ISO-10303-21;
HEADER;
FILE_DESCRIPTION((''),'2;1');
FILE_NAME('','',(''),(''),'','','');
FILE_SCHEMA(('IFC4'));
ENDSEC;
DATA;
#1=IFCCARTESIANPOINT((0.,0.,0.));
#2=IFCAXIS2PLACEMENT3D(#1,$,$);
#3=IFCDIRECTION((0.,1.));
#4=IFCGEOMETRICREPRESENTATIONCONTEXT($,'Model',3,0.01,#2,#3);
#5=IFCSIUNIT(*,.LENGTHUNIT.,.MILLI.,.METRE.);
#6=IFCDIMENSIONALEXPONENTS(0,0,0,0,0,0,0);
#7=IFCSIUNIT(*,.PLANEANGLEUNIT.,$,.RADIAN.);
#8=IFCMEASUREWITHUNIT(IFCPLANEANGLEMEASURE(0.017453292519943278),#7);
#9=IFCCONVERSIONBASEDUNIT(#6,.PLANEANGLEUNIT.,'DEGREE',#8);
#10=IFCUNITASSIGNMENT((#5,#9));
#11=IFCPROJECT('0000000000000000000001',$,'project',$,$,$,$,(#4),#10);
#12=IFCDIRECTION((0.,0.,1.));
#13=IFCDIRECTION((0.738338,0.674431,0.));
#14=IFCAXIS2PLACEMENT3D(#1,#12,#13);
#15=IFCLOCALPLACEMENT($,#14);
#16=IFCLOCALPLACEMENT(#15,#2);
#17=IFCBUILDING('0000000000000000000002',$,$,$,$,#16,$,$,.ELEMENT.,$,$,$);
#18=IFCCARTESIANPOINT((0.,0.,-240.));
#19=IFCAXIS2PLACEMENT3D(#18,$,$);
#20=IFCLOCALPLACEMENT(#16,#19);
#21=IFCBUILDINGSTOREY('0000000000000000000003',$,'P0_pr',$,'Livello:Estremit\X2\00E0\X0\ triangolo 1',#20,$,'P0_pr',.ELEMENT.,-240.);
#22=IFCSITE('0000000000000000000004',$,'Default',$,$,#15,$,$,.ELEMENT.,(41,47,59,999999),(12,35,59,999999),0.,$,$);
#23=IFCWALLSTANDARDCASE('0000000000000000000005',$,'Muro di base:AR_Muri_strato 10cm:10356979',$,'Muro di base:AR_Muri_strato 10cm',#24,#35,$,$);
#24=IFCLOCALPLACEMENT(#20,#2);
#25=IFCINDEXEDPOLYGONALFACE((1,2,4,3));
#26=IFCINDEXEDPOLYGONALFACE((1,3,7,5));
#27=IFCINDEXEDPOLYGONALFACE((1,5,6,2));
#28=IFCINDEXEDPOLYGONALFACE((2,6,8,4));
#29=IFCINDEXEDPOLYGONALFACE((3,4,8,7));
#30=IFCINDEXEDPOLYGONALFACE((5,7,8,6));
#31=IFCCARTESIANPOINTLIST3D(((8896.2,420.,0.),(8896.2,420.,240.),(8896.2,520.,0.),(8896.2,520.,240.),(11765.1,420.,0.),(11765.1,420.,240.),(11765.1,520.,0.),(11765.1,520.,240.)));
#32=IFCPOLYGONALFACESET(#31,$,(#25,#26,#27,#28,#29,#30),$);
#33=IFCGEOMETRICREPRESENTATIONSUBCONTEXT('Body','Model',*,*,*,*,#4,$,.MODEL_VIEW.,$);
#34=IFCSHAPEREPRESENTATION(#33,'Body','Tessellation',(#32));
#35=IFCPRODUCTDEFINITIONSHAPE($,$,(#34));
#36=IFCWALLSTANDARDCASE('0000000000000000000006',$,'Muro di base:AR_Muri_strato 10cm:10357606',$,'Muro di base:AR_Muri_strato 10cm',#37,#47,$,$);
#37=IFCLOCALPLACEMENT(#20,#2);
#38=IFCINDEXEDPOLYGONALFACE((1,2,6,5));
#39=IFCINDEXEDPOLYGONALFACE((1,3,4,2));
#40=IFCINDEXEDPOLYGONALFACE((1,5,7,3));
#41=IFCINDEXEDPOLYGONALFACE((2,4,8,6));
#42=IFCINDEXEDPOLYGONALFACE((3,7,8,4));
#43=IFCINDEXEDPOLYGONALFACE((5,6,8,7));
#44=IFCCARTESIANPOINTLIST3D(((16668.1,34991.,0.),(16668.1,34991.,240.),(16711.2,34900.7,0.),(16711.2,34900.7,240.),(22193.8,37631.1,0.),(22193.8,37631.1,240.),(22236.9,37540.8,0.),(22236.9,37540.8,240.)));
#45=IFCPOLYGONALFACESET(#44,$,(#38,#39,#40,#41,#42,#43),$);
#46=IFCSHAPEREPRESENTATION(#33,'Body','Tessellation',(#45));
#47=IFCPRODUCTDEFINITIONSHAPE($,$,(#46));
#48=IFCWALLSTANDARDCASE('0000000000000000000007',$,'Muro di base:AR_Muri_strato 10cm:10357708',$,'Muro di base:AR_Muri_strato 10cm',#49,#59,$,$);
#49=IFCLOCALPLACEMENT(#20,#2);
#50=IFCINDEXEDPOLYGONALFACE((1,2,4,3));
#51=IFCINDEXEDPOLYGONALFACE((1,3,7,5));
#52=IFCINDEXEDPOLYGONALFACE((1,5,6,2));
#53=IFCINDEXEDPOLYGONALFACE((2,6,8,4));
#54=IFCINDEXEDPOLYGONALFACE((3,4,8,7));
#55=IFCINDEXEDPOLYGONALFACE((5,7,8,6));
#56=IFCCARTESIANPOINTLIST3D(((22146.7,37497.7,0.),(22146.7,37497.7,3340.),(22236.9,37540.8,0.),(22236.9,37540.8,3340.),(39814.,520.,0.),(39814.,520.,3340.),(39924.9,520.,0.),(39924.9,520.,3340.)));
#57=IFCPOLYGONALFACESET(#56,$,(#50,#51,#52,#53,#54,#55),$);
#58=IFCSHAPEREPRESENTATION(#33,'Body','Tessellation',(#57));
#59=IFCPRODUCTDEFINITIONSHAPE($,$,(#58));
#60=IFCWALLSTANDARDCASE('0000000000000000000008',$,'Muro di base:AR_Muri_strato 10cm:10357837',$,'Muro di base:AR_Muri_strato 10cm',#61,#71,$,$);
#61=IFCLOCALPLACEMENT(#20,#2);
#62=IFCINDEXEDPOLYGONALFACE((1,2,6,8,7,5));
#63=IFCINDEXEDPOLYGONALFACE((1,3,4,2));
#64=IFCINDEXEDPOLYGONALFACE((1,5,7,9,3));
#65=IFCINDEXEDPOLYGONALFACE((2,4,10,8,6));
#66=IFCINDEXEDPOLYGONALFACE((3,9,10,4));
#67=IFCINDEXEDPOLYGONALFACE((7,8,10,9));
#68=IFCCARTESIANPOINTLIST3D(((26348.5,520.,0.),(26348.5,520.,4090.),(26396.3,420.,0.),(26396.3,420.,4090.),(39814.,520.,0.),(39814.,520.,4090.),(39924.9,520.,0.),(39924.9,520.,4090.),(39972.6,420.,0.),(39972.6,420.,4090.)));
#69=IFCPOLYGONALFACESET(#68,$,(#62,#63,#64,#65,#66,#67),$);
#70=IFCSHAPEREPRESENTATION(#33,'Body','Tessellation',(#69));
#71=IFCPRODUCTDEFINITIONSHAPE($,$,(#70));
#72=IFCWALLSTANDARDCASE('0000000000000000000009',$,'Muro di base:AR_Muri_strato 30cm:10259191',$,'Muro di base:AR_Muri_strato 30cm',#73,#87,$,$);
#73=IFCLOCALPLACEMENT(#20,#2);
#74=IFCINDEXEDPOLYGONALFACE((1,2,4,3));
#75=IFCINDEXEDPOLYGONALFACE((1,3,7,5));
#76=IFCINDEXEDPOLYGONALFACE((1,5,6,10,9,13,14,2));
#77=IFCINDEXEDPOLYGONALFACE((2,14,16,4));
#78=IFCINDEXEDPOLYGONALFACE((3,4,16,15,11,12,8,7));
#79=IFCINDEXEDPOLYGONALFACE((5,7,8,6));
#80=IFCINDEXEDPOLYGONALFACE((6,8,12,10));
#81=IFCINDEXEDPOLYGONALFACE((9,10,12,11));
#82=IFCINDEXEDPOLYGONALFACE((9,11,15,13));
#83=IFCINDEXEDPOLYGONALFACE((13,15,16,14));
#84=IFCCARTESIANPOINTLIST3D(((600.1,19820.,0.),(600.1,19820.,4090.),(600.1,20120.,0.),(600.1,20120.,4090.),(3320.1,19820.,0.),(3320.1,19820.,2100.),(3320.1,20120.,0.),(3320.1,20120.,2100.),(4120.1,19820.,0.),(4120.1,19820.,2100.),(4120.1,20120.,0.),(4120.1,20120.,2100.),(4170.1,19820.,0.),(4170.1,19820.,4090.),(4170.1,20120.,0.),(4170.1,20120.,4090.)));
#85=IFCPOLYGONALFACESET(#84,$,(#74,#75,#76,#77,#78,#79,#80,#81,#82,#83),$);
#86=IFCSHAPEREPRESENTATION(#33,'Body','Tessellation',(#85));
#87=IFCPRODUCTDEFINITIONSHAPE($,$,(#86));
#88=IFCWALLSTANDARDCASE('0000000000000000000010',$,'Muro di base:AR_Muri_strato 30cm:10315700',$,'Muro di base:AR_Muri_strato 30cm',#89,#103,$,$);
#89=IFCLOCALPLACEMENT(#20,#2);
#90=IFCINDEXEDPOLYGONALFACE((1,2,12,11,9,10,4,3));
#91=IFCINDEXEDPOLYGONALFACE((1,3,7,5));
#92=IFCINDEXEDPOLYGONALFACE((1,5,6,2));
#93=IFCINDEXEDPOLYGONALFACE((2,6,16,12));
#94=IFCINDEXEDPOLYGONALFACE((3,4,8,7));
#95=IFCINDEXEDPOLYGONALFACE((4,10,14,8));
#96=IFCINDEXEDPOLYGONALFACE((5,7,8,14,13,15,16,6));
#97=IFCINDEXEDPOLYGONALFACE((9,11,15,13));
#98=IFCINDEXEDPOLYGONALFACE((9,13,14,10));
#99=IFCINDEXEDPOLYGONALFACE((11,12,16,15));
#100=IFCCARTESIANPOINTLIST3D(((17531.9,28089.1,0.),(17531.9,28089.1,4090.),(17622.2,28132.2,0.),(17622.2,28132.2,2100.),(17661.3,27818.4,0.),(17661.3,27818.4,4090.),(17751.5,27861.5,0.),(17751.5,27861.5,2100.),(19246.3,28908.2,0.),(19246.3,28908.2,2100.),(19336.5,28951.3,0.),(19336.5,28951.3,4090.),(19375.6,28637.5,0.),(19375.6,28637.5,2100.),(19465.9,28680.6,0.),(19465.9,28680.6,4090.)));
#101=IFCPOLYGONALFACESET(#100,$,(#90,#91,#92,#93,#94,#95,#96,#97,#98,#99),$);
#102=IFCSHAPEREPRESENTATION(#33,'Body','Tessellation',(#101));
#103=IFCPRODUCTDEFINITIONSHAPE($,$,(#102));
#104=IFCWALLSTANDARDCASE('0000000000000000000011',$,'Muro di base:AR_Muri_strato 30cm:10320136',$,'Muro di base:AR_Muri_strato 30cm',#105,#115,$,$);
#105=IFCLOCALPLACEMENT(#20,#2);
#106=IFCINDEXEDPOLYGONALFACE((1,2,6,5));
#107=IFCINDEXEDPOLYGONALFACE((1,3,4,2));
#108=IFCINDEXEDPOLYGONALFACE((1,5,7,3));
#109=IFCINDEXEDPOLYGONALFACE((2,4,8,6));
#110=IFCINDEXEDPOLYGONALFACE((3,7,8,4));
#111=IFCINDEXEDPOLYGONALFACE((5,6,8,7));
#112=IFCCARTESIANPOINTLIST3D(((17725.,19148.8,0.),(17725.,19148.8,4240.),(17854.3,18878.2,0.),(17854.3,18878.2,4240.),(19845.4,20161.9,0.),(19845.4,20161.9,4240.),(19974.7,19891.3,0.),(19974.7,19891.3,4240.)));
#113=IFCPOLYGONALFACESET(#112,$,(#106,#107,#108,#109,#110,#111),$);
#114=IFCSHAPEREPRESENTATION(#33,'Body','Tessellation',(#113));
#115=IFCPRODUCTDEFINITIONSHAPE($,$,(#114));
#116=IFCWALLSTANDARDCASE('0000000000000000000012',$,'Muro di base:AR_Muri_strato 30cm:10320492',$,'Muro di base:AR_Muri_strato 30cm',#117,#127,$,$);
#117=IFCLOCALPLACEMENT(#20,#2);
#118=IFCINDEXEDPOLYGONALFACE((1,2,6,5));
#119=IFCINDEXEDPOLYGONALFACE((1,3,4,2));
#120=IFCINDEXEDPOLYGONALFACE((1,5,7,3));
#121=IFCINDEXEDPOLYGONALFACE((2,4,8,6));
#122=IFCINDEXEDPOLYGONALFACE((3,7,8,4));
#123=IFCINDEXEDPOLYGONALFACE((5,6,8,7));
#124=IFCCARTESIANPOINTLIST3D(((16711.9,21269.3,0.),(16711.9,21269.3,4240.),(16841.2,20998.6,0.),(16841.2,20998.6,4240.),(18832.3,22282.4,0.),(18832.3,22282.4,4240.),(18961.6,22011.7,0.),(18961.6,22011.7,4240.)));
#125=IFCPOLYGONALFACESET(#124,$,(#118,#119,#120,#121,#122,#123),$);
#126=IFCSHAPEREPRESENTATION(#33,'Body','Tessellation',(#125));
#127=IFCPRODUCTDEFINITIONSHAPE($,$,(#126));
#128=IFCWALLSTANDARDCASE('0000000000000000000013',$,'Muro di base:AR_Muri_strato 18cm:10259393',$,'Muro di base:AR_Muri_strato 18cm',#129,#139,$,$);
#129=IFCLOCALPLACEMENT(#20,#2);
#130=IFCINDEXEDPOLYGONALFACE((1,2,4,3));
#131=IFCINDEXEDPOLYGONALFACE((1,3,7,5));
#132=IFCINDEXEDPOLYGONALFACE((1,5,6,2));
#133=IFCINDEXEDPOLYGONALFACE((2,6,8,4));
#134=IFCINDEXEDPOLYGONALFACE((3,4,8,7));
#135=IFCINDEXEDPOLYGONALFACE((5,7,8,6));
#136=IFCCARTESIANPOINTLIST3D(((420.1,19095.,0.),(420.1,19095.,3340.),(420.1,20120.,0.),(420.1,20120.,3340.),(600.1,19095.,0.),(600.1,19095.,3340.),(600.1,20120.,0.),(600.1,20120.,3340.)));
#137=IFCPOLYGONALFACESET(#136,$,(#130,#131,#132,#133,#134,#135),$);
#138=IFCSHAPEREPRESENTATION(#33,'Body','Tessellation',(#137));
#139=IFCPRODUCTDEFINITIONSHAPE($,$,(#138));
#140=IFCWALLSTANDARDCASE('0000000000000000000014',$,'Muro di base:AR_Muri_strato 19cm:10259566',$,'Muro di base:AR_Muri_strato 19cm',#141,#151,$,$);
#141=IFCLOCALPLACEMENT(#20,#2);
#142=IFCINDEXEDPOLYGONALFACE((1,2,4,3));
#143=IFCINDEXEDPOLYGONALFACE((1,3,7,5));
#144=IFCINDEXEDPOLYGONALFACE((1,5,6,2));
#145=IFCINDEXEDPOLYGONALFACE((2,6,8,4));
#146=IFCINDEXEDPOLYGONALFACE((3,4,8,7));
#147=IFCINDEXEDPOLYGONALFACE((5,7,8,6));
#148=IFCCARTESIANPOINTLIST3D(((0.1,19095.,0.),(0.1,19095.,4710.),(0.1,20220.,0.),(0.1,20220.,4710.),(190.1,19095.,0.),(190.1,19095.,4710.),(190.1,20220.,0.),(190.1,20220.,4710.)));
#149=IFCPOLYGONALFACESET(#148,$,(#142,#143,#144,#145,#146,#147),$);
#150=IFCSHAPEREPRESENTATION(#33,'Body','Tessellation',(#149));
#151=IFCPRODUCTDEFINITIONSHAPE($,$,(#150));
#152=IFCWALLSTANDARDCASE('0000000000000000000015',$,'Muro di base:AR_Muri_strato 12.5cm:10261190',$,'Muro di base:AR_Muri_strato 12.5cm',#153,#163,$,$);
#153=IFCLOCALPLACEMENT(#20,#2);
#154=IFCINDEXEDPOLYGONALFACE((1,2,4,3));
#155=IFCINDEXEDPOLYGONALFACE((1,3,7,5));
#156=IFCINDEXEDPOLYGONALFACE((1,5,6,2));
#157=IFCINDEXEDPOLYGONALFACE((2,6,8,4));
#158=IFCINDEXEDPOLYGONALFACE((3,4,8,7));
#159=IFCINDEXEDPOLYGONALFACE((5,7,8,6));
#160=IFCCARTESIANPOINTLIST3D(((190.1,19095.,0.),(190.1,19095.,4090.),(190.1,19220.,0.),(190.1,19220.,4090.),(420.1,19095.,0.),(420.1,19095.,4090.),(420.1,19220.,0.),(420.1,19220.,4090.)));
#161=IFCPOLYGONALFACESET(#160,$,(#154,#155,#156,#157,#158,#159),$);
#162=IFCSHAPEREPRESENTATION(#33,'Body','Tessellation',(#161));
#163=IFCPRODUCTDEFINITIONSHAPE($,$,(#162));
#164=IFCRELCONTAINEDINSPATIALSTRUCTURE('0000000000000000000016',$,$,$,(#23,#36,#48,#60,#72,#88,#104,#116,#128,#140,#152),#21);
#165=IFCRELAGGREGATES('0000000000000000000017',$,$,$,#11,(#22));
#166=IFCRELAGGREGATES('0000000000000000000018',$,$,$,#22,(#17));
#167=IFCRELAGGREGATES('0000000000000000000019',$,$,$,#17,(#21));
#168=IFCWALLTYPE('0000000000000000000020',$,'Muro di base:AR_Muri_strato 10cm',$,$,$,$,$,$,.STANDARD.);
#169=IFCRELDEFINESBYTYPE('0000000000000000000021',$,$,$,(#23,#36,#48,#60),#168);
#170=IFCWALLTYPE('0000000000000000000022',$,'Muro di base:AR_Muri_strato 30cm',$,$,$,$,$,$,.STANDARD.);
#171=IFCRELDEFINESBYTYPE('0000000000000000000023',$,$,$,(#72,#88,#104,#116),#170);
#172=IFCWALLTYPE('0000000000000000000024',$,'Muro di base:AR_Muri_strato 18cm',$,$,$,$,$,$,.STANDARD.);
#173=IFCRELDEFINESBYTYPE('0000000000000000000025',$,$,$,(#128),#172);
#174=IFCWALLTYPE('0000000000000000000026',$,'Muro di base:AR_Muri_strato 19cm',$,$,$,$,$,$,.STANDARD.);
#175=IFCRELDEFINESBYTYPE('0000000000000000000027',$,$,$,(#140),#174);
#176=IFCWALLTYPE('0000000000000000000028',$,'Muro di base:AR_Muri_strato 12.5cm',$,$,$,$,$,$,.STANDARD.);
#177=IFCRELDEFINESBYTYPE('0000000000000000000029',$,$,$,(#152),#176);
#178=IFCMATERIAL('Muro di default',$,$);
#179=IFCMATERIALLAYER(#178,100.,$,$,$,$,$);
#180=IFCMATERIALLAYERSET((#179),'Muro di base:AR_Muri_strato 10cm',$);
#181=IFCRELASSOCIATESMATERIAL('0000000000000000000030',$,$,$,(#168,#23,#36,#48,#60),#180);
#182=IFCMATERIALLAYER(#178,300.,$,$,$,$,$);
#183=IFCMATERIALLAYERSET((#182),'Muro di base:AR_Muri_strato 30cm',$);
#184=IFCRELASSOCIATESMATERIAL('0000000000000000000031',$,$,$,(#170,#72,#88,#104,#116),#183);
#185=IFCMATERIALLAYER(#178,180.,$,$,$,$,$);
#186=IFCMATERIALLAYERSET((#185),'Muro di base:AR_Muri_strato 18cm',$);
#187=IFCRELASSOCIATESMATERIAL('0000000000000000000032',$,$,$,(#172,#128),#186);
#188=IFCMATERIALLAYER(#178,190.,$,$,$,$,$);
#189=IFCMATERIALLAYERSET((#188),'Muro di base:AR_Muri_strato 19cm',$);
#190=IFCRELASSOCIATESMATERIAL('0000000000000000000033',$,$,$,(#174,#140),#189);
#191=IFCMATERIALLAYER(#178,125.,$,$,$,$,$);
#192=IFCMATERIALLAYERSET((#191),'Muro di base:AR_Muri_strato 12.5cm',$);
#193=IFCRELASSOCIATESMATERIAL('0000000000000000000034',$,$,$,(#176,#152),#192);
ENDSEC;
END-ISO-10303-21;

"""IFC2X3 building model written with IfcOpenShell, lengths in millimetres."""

from ifc_helpers import new_model, entity, si_unit, converted_unit, direction, frame, frame_2d, origin, place, context, subcontext, project, spatial, polyline, rectangle, outline, extrude, material, layer, layer_set, layer_usage, type_object, element, save


model = new_model("IFC2X3")

# Units and contexts
model_context = context("Model", 3, precision=0.01, world=origin(), true_north=direction((0.0, 1.0)))
body_context = subcontext(model_context, "Body", "Model", "MODEL_VIEW")
ifc_project = project(units=[si_unit("LENGTHUNIT", "METRE", prefix="MILLI"), converted_unit("PLANEANGLEUNIT", "DEGREE", entity("IfcPlaneAngleMeasure", 0.017453292519943278), si_unit("PLANEANGLEUNIT", "RADIAN"), dimensions=[0, 0, 0, 0, 0, 0, 0])], contexts=[model_context])

# Site, building, storey
site_placement = place(None, frame((0.0, 0.0, 0.0), z_axis=(0.0, 0.0, 1.0), x_axis=(0.738338, 0.674431, 0.0)))
site = spatial("IfcSite", under=ifc_project, at=site_placement, Name="Default", CompositionType="ELEMENT", RefLatitude=(41, 47, 59, 999999), RefLongitude=(12, 35, 59, 999999), RefElevation=0.0)
building_placement = place(site_placement, origin())
building = spatial("IfcBuilding", under=site, at=building_placement, CompositionType="ELEMENT")
storey_placement = place(building_placement, frame((0.0, 0.0, -240.0)))
storey = spatial("IfcBuildingStorey", under=building, at=storey_placement, Name="P0_pr", ObjectType="Livello:Estremità triangolo 1", LongName="P0_pr", CompositionType="ELEMENT", Elevation=-240.0)

# Walls
ifc_material = material(Name="Muro di default")
ifc_layer_1 = layer(ifc_material, 100.0)
ifc_layer_set_1 = layer_set([ifc_layer_1], Name="Muro di base:AR_Muri_strato 10cm")
ifc_layer_usage_1 = layer_usage(ifc_layer_set_1, "AXIS2", "NEGATIVE", 50.0)
wall_type_1 = type_object("IfcWallType", Name="Muro di base:AR_Muri_strato 10cm", PredefinedType="STANDARD", material=ifc_layer_set_1)
wall_1_placement = place(storey_placement, frame((11765.1, 470.0, 0.0), z_axis=(0.0, 0.0, 1.0), x_axis=(-1.0, 0.0, 0.0)))
element("IfcWallStandardCase", 1, at=wall_1_placement, inside=storey, type_object=wall_type_1, material=ifc_layer_usage_1, Name="Muro di base:AR_Muri_strato 10cm:10356979", ObjectType="Muro di base:AR_Muri_strato 10cm", context=body_context, shape_type="SweptSolid", body=[
    extrude(rectangle(XDim=2868.8, YDim=100.0, at=frame_2d((1434.4, 0.0), x_axis=(-1.0, 0.0))), origin(), (0.0, 0.0, 1.0), 240.0),
])
ifc_layer_usage_2 = layer_usage(ifc_layer_set_1, "AXIS2", "NEGATIVE", 50.0)
wall_2_placement = place(storey_placement, frame((16689.7, 34945.9, 0.0), z_axis=(0.0, 0.0, 1.0), x_axis=(0.902302, 0.431105, 0.0)))
element("IfcWallStandardCase", 2, at=wall_2_placement, inside=storey, type_object=wall_type_1, material=ifc_layer_usage_2, Name="Muro di base:AR_Muri_strato 10cm:10357606", ObjectType="Muro di base:AR_Muri_strato 10cm", context=body_context, shape_type="SweptSolid", body=[
    extrude(rectangle(XDim=6124.0, YDim=100.0, at=frame_2d((3062.0, 0.0), x_axis=(-1.0, 0.0))), origin(), (0.0, 0.0, 1.0), 240.0),
])
ifc_layer_usage_3 = layer_usage(ifc_layer_set_1, "AXIS2", "NEGATIVE", 50.0)
wall_3_placement = place(storey_placement, frame((22191.8, 37519.3, 0.0), z_axis=(0.0, 0.0, 1.0), x_axis=(0.431105, -0.902302, 0.0)))
element("IfcWallStandardCase", 3, at=wall_3_placement, inside=storey, type_object=wall_type_1, material=ifc_layer_usage_3, Name="Muro di base:AR_Muri_strato 10cm:10357708", ObjectType="Muro di base:AR_Muri_strato 10cm", context=body_context, shape_type="SweptSolid", body=[
    extrude(outline(polyline([(40981.5, -50.0), (41029.3, 50.0), (0.0, 50.0), (0.0, -50.0), (40981.5, -50.0)])), origin(), (0.0, 0.0, 1.0), 3340.0),
])
ifc_layer_usage_4 = layer_usage(ifc_layer_set_1, "AXIS2", "NEGATIVE", 50.0)
wall_4_placement = place(storey_placement, frame((39972.6, 470.0, 0.0), z_axis=(0.0, 0.0, 1.0), x_axis=(-1.0, 0.0, 0.0)))
element("IfcWallStandardCase", 4, at=wall_4_placement, inside=storey, type_object=wall_type_1, material=ifc_layer_usage_4, Name="Muro di base:AR_Muri_strato 10cm:10357837", ObjectType="Muro di base:AR_Muri_strato 10cm", context=body_context, shape_type="SweptSolid", body=[
    extrude(outline(polyline([(13624.2, -50.0), (13576.4, 50.0), (0.0, 50.0), (47.8, -50.0), (158.6, -50.0), (13624.2, -50.0)])), origin(), (0.0, 0.0, 1.0), 4090.0),
])

# Walls, openings
ifc_layer_2 = layer(ifc_material, 300.0)
ifc_layer_set_2 = layer_set([ifc_layer_2], Name="Muro di base:AR_Muri_strato 30cm")
ifc_layer_usage_5 = layer_usage(ifc_layer_set_2, "AXIS2", "NEGATIVE", 150.0)
wall_type_2 = type_object("IfcWallType", Name="Muro di base:AR_Muri_strato 30cm", PredefinedType="STANDARD", material=ifc_layer_set_2)
wall_5_placement = place(storey_placement, frame((4170.1, 19970.0, 0.0), z_axis=(0.0, 0.0, 1.0), x_axis=(-1.0, 0.0, 0.0)))
wall_5 = element("IfcWallStandardCase", 5, at=wall_5_placement, inside=storey, type_object=wall_type_2, material=ifc_layer_usage_5, Name="Muro di base:AR_Muri_strato 30cm:10259191", ObjectType="Muro di base:AR_Muri_strato 30cm", context=body_context, shape_type="SweptSolid", body=[
    extrude(rectangle(XDim=3570.0, YDim=300.0, at=frame_2d((1785.0, 0.0), x_axis=(1.0, 0.0))), origin(), (0.0, 0.0, 1.0), 4090.0),
])
opening_1_placement = place(wall_5_placement, frame((4170.1, 19970.0, 0.0), z_axis=(0.0, 0.0, 1.0), x_axis=(-1.0, 0.0, 0.0)))
element("IfcOpeningElement", 6, at=opening_1_placement, cuts=wall_5, ObjectType="Opening", context=body_context, shape_type="SweptSolid", body=[
    extrude(rectangle(XDim=2100.0, YDim=800.0, at=frame_2d((0.0, 0.0), x_axis=(0.0, 1.0))), frame((3720.1, 21644.0, 1050.0), z_axis=(0.0, -1.0, 0.0), x_axis=(-1.0, 0.0, 0.0)), (0.0, 0.0, 1.0), 3048.0),
])
ifc_layer_usage_6 = layer_usage(ifc_layer_set_2, "AXIS2", "NEGATIVE", 150.0)
wall_6_placement = place(storey_placement, frame((17596.6, 27953.7, 0.0), z_axis=(0.0, 0.0, 1.0), x_axis=(0.902302, 0.431105, 0.0)))
wall_6 = element("IfcWallStandardCase", 7, at=wall_6_placement, inside=storey, type_object=wall_type_2, material=ifc_layer_usage_6, Name="Muro di base:AR_Muri_strato 30cm:10315700", ObjectType="Muro di base:AR_Muri_strato 30cm", context=body_context, shape_type="SweptSolid", body=[
    extrude(rectangle(XDim=2000.0, YDim=300.0, at=frame_2d((1000.0, 0.0), x_axis=(-1.0, 0.0))), origin(), (0.0, 0.0, 1.0), 4090.0),
])
opening_2_placement = place(wall_6_placement, frame((-27928.4, -17636.7, 0.0), z_axis=(0.0, 0.0, 1.0), x_axis=(0.902302, -0.431105, 0.0)))
element("IfcOpeningElement", 8, at=opening_2_placement, cuts=wall_6, ObjectType="Opening", context=body_context, shape_type="SweptSolid", body=[
    extrude(rectangle(XDim=2100.0, YDim=1800.0, at=frame_2d((0.0, 0.0), x_axis=(1.0, 0.0))), frame((19091.2, 27145.1, 1050.0), z_axis=(-0.431105, 0.902302, 0.0), x_axis=(0.0, 0.0, -1.0)), (0.0, 0.0, 1.0), 3048.0),
])

# Walls
ifc_layer_usage_7 = layer_usage(ifc_layer_set_2, "AXIS2", "NEGATIVE", 150.0)
wall_7_placement = place(storey_placement, frame((19910.0, 20026.6, 0.0), z_axis=(0.0, 0.0, 1.0), x_axis=(-0.902302, -0.431105, 0.0)))
element("IfcWallStandardCase", 9, at=wall_7_placement, inside=storey, type_object=wall_type_2, material=ifc_layer_usage_7, Name="Muro di base:AR_Muri_strato 30cm:10320136", ObjectType="Muro di base:AR_Muri_strato 30cm", context=body_context, shape_type="SweptSolid", body=[
    extrude(rectangle(XDim=2350.0, YDim=300.0, at=frame_2d((1175.0, 0.0), x_axis=(-1.0, 0.0))), origin(), (0.0, 0.0, 1.0), 4240.0),
])
ifc_layer_usage_8 = layer_usage(ifc_layer_set_2, "AXIS2", "NEGATIVE", 150.0)
wall_8_placement = place(storey_placement, frame((18896.9, 22147.0, 0.0), z_axis=(0.0, 0.0, 1.0), x_axis=(-0.902302, -0.431105, 0.0)))
element("IfcWallStandardCase", 10, at=wall_8_placement, inside=storey, type_object=wall_type_2, material=ifc_layer_usage_8, Name="Muro di base:AR_Muri_strato 30cm:10320492", ObjectType="Muro di base:AR_Muri_strato 30cm", context=body_context, shape_type="SweptSolid", body=[
    extrude(rectangle(XDim=2350.0, YDim=300.0, at=frame_2d((1175.0, 0.0), x_axis=(-1.0, 0.0))), origin(), (0.0, 0.0, 1.0), 4240.0),
])
ifc_layer_3 = layer(ifc_material, 180.0)
ifc_layer_set_3 = layer_set([ifc_layer_3], Name="Muro di base:AR_Muri_strato 18cm")
ifc_layer_usage_9 = layer_usage(ifc_layer_set_3, "AXIS2", "NEGATIVE", 90.0)
wall_type_3 = type_object("IfcWallType", Name="Muro di base:AR_Muri_strato 18cm", PredefinedType="STANDARD", material=ifc_layer_set_3)
wall_9_placement = place(storey_placement, frame((510.1, 20120.0, 0.0), z_axis=(0.0, 0.0, 1.0), x_axis=(0.0, -1.0, 0.0)))
element("IfcWallStandardCase", 11, at=wall_9_placement, inside=storey, type_object=wall_type_3, material=ifc_layer_usage_9, Name="Muro di base:AR_Muri_strato 18cm:10259393", ObjectType="Muro di base:AR_Muri_strato 18cm", context=body_context, shape_type="SweptSolid", body=[
    extrude(rectangle(XDim=1025.0, YDim=180.0, at=frame_2d((512.5, 0.0), x_axis=(-1.0, 0.0))), origin(), (0.0, 0.0, 1.0), 3340.0),
])
ifc_layer_4 = layer(ifc_material, 190.0)
ifc_layer_set_4 = layer_set([ifc_layer_4], Name="Muro di base:AR_Muri_strato 19cm")
ifc_layer_usage_10 = layer_usage(ifc_layer_set_4, "AXIS2", "POSITIVE", -95.0)
wall_type_4 = type_object("IfcWallType", Name="Muro di base:AR_Muri_strato 19cm", PredefinedType="STANDARD", material=ifc_layer_set_4)
wall_10_placement = place(storey_placement, frame((95.1, 20220.0, 0.0), z_axis=(0.0, 0.0, 1.0), x_axis=(0.0, -1.0, 0.0)))
element("IfcWallStandardCase", 12, at=wall_10_placement, inside=storey, type_object=wall_type_4, material=ifc_layer_usage_10, Name="Muro di base:AR_Muri_strato 19cm:10259566", ObjectType="Muro di base:AR_Muri_strato 19cm", context=body_context, shape_type="SweptSolid", body=[
    extrude(rectangle(XDim=1125.0, YDim=190.0, at=frame_2d((562.5, 0.0), x_axis=(-1.0, 0.0))), origin(), (0.0, 0.0, 1.0), 4710.0),
])
ifc_layer_5 = layer(ifc_material, 125.0)
ifc_layer_set_5 = layer_set([ifc_layer_5], Name="Muro di base:AR_Muri_strato 12.5cm")
ifc_layer_usage_11 = layer_usage(ifc_layer_set_5, "AXIS2", "NEGATIVE", 62.5)
wall_type_5 = type_object("IfcWallType", Name="Muro di base:AR_Muri_strato 12.5cm", PredefinedType="STANDARD", material=ifc_layer_set_5)
wall_11_placement = place(storey_placement, frame((190.1, 19157.5, 0.0)))
element("IfcWallStandardCase", 13, at=wall_11_placement, inside=storey, type_object=wall_type_5, material=ifc_layer_usage_11, Name="Muro di base:AR_Muri_strato 12.5cm:10261190", ObjectType="Muro di base:AR_Muri_strato 12.5cm", context=body_context, shape_type="SweptSolid", body=[
    extrude(rectangle(XDim=230.0, YDim=125.0, at=frame_2d((115.0, 0.0), x_axis=(-1.0, 0.0))), origin(), (0.0, 0.0, 1.0), 4090.0),
])

save(model, "model.ifc")
